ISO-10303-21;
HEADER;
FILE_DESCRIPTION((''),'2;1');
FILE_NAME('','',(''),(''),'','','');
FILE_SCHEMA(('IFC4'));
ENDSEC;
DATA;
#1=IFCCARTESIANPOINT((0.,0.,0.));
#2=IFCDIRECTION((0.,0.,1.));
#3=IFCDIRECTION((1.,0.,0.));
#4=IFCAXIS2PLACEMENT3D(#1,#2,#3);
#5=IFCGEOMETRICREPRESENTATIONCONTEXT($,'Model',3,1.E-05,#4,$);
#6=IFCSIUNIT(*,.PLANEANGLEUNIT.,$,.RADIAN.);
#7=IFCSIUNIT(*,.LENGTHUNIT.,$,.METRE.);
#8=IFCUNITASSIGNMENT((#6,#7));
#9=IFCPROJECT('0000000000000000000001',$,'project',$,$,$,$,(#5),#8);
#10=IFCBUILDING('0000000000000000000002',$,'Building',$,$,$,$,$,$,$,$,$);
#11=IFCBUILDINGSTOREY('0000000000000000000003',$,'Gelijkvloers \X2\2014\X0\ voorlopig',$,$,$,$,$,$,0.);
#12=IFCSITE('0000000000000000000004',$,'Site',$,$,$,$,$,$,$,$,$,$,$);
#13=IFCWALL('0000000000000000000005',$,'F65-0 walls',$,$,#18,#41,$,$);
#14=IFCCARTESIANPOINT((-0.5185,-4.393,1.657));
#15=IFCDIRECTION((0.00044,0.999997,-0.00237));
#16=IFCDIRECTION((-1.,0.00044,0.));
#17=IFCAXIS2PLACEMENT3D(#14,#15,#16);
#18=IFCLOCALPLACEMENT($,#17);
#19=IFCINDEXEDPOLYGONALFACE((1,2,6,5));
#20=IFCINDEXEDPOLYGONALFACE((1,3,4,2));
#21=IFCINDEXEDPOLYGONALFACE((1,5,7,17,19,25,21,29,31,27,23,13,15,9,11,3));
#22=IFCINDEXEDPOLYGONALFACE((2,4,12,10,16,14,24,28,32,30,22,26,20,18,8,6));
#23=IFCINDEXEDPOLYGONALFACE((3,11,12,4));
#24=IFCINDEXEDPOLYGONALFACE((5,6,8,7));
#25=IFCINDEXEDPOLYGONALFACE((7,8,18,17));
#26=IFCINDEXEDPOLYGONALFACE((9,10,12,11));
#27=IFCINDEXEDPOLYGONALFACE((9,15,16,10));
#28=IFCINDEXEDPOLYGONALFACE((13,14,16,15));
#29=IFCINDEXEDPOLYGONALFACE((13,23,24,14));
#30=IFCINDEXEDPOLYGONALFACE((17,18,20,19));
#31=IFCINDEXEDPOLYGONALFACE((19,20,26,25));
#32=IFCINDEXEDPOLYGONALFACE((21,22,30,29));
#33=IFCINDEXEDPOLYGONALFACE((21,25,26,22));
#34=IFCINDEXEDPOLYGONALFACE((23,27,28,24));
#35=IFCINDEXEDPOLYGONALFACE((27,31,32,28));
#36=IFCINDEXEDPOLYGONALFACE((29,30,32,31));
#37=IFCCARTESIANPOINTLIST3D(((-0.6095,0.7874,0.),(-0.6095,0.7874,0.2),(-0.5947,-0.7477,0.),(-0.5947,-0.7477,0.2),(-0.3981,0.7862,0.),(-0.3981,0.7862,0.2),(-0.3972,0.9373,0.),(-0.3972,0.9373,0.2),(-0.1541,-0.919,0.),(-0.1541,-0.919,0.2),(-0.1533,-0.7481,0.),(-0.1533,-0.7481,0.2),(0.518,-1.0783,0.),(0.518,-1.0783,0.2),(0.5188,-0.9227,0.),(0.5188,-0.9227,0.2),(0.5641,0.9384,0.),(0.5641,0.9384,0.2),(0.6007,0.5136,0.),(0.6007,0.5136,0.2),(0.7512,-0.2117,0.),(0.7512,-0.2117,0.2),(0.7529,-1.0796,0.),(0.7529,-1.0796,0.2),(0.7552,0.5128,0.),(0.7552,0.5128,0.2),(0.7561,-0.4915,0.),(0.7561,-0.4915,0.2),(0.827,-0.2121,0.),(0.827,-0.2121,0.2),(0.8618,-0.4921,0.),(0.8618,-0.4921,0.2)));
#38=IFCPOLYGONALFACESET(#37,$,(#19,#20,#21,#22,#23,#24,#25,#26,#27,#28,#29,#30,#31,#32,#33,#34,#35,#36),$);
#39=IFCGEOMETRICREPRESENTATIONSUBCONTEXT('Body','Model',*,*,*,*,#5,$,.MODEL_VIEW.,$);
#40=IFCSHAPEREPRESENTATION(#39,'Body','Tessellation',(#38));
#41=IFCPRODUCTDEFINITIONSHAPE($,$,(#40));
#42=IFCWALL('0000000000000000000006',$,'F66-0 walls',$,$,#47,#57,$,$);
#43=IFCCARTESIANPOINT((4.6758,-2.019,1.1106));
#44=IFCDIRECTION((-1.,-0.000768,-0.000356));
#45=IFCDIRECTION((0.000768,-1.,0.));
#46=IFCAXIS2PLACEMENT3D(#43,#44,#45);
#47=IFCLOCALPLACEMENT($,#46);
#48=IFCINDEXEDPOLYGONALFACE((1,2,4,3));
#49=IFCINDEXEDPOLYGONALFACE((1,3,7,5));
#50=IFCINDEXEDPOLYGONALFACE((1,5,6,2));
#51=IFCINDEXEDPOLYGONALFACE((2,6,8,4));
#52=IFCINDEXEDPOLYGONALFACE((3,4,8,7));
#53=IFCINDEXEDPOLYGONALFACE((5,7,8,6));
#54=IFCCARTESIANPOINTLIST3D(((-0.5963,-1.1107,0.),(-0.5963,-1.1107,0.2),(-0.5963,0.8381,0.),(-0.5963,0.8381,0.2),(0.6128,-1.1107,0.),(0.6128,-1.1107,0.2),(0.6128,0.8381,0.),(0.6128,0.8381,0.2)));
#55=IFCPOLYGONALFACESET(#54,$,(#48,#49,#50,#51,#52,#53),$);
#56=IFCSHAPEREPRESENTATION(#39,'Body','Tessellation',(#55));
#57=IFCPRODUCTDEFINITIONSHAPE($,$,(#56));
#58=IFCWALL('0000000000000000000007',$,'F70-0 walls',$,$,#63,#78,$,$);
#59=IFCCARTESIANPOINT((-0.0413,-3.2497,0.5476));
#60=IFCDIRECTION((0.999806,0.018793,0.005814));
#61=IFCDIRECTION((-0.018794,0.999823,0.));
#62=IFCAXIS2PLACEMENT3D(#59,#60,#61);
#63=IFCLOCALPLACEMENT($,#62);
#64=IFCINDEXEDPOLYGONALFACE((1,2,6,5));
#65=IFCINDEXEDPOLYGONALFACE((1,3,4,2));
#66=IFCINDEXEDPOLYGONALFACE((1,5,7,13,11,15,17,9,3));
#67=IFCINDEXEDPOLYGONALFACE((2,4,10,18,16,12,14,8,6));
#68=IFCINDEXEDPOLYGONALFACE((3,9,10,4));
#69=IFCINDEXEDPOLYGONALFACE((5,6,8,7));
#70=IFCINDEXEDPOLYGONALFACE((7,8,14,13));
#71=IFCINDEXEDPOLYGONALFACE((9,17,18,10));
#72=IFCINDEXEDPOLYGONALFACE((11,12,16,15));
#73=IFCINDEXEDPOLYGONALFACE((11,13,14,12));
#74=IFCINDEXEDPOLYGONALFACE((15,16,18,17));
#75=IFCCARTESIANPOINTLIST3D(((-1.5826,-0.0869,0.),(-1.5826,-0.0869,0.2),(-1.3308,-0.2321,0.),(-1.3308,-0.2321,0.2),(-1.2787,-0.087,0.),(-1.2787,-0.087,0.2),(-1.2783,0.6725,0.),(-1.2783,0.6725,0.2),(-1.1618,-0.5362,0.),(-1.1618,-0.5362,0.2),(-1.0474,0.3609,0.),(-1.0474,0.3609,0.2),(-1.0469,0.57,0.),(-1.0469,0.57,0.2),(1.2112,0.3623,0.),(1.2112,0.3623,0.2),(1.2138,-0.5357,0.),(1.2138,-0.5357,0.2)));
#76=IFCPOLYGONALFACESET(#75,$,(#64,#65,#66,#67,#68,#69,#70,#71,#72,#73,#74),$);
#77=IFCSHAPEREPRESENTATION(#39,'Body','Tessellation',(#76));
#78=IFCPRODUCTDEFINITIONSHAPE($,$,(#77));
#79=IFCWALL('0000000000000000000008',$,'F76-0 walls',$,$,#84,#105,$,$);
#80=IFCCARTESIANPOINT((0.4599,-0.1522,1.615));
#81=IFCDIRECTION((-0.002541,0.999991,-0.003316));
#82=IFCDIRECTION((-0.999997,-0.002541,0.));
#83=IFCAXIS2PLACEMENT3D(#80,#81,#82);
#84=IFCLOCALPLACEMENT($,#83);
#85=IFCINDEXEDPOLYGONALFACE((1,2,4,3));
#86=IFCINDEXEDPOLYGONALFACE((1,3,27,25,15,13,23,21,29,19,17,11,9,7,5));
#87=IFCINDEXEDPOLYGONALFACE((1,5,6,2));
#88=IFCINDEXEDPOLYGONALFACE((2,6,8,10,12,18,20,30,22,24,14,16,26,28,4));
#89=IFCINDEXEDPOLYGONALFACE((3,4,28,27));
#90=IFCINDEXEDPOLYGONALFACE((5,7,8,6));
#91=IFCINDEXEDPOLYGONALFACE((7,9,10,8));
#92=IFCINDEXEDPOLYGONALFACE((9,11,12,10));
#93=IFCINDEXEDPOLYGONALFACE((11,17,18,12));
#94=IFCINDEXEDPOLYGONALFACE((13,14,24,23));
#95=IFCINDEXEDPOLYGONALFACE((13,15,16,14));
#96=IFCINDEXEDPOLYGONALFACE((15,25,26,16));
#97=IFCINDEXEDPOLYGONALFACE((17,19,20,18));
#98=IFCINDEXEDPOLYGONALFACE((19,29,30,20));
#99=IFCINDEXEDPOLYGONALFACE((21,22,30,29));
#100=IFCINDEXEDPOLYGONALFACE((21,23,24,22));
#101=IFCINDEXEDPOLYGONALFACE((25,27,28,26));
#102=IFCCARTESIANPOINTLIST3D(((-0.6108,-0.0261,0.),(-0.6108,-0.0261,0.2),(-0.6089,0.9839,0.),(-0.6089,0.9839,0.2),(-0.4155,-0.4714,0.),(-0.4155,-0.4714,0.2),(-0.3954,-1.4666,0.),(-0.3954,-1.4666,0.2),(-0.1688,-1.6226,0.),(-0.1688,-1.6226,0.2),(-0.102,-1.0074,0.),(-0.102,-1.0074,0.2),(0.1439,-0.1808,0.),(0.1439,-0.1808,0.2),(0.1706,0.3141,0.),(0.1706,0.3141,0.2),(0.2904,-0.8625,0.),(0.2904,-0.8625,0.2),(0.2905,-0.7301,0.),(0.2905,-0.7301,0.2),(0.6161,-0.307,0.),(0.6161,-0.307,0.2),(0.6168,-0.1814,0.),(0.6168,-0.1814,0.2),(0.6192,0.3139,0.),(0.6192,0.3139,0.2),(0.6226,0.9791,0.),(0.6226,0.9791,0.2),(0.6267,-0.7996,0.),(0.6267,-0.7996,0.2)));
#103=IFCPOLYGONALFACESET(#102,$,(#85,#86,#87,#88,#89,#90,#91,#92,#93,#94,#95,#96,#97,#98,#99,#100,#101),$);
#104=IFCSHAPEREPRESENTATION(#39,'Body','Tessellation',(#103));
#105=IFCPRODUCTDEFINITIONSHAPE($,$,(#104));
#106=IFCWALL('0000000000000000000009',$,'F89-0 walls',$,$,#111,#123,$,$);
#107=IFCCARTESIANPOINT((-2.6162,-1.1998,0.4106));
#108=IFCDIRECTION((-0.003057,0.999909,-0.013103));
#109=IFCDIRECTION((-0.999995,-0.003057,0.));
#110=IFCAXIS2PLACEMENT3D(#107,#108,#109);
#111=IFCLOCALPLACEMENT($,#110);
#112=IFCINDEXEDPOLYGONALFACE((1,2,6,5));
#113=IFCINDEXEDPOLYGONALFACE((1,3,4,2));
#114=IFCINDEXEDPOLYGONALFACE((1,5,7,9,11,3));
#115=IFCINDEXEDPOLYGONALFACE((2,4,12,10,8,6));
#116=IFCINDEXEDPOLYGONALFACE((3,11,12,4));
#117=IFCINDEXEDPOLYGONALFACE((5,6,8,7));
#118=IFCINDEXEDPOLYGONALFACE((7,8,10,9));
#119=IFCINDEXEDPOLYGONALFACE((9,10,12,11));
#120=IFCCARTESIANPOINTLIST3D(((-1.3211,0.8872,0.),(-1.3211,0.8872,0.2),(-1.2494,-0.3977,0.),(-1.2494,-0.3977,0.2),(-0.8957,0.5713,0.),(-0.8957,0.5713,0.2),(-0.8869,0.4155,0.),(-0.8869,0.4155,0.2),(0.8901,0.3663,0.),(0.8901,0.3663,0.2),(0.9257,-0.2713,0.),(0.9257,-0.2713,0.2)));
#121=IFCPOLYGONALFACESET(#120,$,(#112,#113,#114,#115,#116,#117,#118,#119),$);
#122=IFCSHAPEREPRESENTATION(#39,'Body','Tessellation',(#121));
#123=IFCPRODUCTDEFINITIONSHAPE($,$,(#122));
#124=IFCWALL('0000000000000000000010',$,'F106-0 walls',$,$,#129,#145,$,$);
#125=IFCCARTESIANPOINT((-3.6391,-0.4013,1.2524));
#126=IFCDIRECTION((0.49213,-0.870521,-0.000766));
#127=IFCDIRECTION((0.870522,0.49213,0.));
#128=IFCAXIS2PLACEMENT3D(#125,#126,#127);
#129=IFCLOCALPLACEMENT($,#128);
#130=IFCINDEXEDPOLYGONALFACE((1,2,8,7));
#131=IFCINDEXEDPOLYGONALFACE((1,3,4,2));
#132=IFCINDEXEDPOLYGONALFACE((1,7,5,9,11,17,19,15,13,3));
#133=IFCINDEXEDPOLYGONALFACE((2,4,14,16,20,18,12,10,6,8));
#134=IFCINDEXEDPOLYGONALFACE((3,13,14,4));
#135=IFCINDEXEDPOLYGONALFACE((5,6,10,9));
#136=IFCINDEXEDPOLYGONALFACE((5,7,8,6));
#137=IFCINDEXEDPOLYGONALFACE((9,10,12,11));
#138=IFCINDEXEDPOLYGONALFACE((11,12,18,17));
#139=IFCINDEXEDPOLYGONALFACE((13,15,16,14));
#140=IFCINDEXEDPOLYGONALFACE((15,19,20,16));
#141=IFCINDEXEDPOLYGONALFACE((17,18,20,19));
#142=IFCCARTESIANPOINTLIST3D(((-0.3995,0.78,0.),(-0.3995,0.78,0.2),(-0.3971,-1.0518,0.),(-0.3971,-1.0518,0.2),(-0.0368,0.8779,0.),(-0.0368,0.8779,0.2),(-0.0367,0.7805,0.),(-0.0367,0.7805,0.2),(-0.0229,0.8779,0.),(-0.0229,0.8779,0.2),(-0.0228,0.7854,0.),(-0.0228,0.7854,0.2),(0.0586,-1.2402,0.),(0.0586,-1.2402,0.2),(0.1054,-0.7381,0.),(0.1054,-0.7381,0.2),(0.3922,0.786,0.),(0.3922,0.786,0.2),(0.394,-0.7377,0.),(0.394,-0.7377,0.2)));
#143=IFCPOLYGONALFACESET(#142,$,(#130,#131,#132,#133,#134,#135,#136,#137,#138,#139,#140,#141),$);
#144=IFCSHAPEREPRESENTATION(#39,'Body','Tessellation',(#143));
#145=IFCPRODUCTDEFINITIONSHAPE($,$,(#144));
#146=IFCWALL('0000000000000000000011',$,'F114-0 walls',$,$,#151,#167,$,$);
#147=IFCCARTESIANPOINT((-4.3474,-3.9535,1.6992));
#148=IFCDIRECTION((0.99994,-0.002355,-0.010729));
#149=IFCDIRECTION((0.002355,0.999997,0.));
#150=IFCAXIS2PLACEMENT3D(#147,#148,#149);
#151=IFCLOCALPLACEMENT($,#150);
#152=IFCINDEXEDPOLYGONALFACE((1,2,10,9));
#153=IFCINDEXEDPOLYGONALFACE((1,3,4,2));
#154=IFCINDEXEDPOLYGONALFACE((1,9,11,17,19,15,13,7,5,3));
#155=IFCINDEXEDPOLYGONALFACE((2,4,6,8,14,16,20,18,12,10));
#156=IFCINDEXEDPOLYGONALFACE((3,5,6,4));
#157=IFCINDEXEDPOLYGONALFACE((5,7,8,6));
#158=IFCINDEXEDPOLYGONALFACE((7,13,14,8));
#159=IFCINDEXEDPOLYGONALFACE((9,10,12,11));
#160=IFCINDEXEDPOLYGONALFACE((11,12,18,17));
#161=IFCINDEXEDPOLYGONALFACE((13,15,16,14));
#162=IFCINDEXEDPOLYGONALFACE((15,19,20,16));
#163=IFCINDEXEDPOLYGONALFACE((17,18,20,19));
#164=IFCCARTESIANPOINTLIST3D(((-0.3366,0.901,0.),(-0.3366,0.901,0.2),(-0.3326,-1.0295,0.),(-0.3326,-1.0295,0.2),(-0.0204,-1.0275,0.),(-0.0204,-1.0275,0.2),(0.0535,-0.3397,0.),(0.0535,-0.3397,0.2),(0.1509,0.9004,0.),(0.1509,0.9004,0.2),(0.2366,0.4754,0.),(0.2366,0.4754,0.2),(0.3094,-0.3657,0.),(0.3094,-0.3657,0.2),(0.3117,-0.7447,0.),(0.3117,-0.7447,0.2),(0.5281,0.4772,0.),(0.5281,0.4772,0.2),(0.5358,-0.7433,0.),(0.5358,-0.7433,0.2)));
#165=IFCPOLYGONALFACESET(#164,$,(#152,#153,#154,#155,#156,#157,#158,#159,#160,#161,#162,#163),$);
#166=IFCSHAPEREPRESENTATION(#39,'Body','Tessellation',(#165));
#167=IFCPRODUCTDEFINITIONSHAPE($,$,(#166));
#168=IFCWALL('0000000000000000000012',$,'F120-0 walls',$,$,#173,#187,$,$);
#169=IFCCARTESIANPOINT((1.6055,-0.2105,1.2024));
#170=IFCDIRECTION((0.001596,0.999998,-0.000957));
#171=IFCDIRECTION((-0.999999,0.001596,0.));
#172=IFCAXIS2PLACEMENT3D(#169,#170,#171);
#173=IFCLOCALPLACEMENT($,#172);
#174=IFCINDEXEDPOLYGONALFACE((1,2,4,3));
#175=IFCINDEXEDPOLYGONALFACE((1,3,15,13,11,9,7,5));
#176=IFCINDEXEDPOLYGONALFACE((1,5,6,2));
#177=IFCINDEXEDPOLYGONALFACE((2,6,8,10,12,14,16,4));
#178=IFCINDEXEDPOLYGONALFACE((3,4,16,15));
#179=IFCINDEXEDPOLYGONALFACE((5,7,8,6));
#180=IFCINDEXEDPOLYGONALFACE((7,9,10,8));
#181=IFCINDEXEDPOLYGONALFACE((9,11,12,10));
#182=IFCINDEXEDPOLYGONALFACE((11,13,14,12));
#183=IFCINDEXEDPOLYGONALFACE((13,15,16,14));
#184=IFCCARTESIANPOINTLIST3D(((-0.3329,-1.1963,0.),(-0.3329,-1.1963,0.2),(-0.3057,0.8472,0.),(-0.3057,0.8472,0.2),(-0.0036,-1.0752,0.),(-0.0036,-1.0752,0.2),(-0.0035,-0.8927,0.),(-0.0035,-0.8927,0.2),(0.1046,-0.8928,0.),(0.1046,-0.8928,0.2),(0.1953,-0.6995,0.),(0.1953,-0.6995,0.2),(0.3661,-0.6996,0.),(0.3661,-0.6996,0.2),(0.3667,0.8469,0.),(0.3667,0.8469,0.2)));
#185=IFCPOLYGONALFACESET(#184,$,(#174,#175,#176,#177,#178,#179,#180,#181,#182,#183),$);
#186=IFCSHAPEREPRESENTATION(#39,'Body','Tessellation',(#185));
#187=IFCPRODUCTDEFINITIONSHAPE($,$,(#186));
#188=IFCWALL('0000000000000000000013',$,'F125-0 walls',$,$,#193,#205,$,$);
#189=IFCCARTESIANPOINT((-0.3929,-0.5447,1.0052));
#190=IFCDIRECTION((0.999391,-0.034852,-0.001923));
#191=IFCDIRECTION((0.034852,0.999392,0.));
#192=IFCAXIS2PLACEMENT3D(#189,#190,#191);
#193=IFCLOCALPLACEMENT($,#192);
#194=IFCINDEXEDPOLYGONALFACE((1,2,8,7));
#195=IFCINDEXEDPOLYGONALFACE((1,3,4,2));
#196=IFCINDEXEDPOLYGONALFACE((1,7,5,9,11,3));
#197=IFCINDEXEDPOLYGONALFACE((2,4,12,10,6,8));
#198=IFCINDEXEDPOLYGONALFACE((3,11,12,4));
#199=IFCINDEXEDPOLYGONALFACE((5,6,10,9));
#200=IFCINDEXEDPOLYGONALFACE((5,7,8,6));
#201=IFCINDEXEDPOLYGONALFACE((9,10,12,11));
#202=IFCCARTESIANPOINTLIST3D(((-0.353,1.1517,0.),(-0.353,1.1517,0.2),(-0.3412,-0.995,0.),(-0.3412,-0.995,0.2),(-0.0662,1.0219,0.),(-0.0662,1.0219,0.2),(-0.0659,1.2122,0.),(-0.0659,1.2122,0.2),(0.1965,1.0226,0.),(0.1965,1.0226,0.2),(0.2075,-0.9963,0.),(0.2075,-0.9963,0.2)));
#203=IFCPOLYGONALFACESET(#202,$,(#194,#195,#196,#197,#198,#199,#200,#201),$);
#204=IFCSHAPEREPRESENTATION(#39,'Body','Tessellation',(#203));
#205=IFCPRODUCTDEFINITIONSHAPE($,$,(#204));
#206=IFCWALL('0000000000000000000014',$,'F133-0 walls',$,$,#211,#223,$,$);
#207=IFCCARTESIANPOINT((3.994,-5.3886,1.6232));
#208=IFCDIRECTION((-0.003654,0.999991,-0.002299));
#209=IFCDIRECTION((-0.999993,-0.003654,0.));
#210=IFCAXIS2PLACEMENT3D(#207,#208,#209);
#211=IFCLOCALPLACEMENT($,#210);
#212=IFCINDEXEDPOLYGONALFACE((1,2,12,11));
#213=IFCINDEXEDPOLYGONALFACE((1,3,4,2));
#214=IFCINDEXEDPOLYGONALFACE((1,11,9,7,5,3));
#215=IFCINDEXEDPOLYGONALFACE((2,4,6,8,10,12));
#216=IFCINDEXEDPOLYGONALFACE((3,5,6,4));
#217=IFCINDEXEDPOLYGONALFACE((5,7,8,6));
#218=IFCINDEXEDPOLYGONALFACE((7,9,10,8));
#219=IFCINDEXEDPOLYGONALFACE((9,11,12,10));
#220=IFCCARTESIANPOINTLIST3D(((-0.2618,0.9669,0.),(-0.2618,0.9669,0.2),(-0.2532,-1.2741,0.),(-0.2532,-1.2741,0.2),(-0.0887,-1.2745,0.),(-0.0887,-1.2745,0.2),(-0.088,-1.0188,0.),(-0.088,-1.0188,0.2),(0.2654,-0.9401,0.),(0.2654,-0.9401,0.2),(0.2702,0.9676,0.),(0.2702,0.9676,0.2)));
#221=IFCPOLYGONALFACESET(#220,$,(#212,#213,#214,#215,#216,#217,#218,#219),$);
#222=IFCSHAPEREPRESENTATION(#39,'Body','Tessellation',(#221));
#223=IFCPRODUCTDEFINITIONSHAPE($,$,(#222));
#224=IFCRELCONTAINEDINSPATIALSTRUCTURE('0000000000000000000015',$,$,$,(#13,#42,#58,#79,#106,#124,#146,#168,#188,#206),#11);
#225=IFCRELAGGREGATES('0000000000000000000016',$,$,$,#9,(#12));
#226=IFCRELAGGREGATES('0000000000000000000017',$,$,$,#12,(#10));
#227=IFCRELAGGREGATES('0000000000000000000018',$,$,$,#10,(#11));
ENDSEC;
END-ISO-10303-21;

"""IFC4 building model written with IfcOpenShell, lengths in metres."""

from ifc_helpers import new_model, si_unit, frame, origin_with_axes, place, context, subcontext, project, spatial, polyline, outline, extrude, element, save


model = new_model("IFC4")

# Units and contexts
model_context = context("Model", 3, precision=1e-05, world=origin_with_axes())
body_context = subcontext(model_context, "Body", "Model", "MODEL_VIEW")
ifc_project = project(units=[si_unit("PLANEANGLEUNIT", "RADIAN"), si_unit("LENGTHUNIT", "METRE")], contexts=[model_context])

# Site, building, storey
site = spatial("IfcSite", under=ifc_project, Name="Site")
building = spatial("IfcBuilding", under=site, Name="Building")
storey = spatial("IfcBuildingStorey", under=building, Name="Gelijkvloers — voorlopig", Elevation=0.0)

# Walls
wall_1_placement = place(None, frame((-0.5185, -4.393, 1.657), z_axis=(0.00044, 0.999997, -0.00237), x_axis=(-1.0, 0.00044, 0.0)))
element("IfcWall", 1, at=wall_1_placement, inside=storey, Name="F65-0 walls", context=body_context, shape_type="SweptSolid", body=[
    extrude(outline(polyline([(0.7529, -1.0796), (0.7561, -0.4915), (0.8618, -0.4921), (0.827, -0.2121), (0.7512, -0.2117), (0.7552, 0.5128), (0.6007, 0.5136), (0.5641, 0.9384), (-0.3972, 0.9373), (-0.3981, 0.7862), (-0.6095, 0.7874), (-0.5947, -0.7477), (-0.1533, -0.7481), (-0.1541, -0.919), (0.5188, -0.9227), (0.518, -1.0783), (0.7529, -1.0796)])), origin_with_axes(), (0.0, 0.0, 1.0), 0.2),
])
wall_2_placement = place(None, frame((4.6758, -2.019, 1.1106), z_axis=(-1.0, -0.000768, -0.000356), x_axis=(0.000768, -1.0, 0.0)))
element("IfcWall", 2, at=wall_2_placement, inside=storey, Name="F66-0 walls", context=body_context, shape_type="SweptSolid", body=[
    extrude(outline(polyline([(-0.5963, -1.1107), (0.6128, -1.1107), (0.6128, 0.8381), (-0.5963, 0.8381), (-0.5963, -1.1107)])), origin_with_axes(), (0.0, 0.0, 1.0), 0.2),
])
wall_3_placement = place(None, frame((-0.0413, -3.2497, 0.5476), z_axis=(0.999806, 0.018793, 0.005814), x_axis=(-0.018794, 0.999823, 0.0)))
element("IfcWall", 3, at=wall_3_placement, inside=storey, Name="F70-0 walls", context=body_context, shape_type="SweptSolid", body=[
    extrude(outline(polyline([(-1.1618, -0.5362), (1.2138, -0.5357), (1.2112, 0.3623), (-1.0474, 0.3609), (-1.0469, 0.57), (-1.2783, 0.6725), (-1.2787, -0.087), (-1.5826, -0.0869), (-1.3308, -0.2321), (-1.1618, -0.5362)])), origin_with_axes(), (0.0, 0.0, 1.0), 0.2),
])
wall_4_placement = place(None, frame((0.4599, -0.1522, 1.615), z_axis=(-0.002541, 0.999991, -0.003316), x_axis=(-0.999997, -0.002541, 0.0)))
element("IfcWall", 4, at=wall_4_placement, inside=storey, Name="F76-0 walls", context=body_context, shape_type="SweptSolid", body=[
    extrude(outline(polyline([(-0.1688, -1.6226), (-0.102, -1.0074), (0.2904, -0.8625), (0.2905, -0.7301), (0.6267, -0.7996), (0.6161, -0.307), (0.6168, -0.1814), (0.1439, -0.1808), (0.1706, 0.3141), (0.6192, 0.3139), (0.6226, 0.9791), (-0.6089, 0.9839), (-0.6108, -0.0261), (-0.4155, -0.4714), (-0.3954, -1.4666), (-0.1688, -1.6226)])), origin_with_axes(), (0.0, 0.0, 1.0), 0.2),
])
wall_5_placement = place(None, frame((-2.6162, -1.1998, 0.4106), z_axis=(-0.003057, 0.999909, -0.013103), x_axis=(-0.999995, -0.003057, 0.0)))
element("IfcWall", 5, at=wall_5_placement, inside=storey, Name="F89-0 walls", context=body_context, shape_type="SweptSolid", body=[
    extrude(outline(polyline([(-1.2494, -0.3977), (0.9257, -0.2713), (0.8901, 0.3663), (-0.8869, 0.4155), (-0.8957, 0.5713), (-1.3211, 0.8872), (-1.2494, -0.3977)])), origin_with_axes(), (0.0, 0.0, 1.0), 0.2),
])
wall_6_placement = place(None, frame((-3.6391, -0.4013, 1.2524), z_axis=(0.49213, -0.870521, -0.000766), x_axis=(0.870522, 0.49213, 0.0)))
element("IfcWall", 6, at=wall_6_placement, inside=storey, Name="F106-0 walls", context=body_context, shape_type="SweptSolid", body=[
    extrude(outline(polyline([(0.0586, -1.2402), (0.1054, -0.7381), (0.394, -0.7377), (0.3922, 0.786), (-0.0228, 0.7854), (-0.0229, 0.8779), (-0.0368, 0.8779), (-0.0367, 0.7805), (-0.3995, 0.78), (-0.3971, -1.0518), (0.0586, -1.2402)])), origin_with_axes(), (0.0, 0.0, 1.0), 0.2),
])
wall_7_placement = place(None, frame((-4.3474, -3.9535, 1.6992), z_axis=(0.99994, -0.002355, -0.010729), x_axis=(0.002355, 0.999997, 0.0)))
element("IfcWall", 7, at=wall_7_placement, inside=storey, Name="F114-0 walls", context=body_context, shape_type="SweptSolid", body=[
    extrude(outline(polyline([(-0.3326, -1.0295), (-0.0204, -1.0275), (0.0535, -0.3397), (0.3094, -0.3657), (0.3117, -0.7447), (0.5358, -0.7433), (0.5281, 0.4772), (0.2366, 0.4754), (0.1509, 0.9004), (-0.3366, 0.901), (-0.3326, -1.0295)])), origin_with_axes(), (0.0, 0.0, 1.0), 0.2),
])
wall_8_placement = place(None, frame((1.6055, -0.2105, 1.2024), z_axis=(0.001596, 0.999998, -0.000957), x_axis=(-0.999999, 0.001596, 0.0)))
element("IfcWall", 8, at=wall_8_placement, inside=storey, Name="F120-0 walls", context=body_context, shape_type="SweptSolid", body=[
    extrude(outline(polyline([(-0.3329, -1.1963), (-0.0036, -1.0752), (-0.0035, -0.8927), (0.1046, -0.8928), (0.1953, -0.6995), (0.3661, -0.6996), (0.3667, 0.8469), (-0.3057, 0.8472), (-0.3329, -1.1963)])), origin_with_axes(), (0.0, 0.0, 1.0), 0.2),
])
wall_9_placement = place(None, frame((-0.3929, -0.5447, 1.0052), z_axis=(0.999391, -0.034852, -0.001923), x_axis=(0.034852, 0.999392, 0.0)))
element("IfcWall", 9, at=wall_9_placement, inside=storey, Name="F125-0 walls", context=body_context, shape_type="SweptSolid", body=[
    extrude(outline(polyline([(-0.3412, -0.995), (0.2075, -0.9963), (0.1965, 1.0226), (-0.0662, 1.0219), (-0.0659, 1.2122), (-0.353, 1.1517), (-0.3412, -0.995)])), origin_with_axes(), (0.0, 0.0, 1.0), 0.2),
])
wall_10_placement = place(None, frame((3.994, -5.3886, 1.6232), z_axis=(-0.003654, 0.999991, -0.002299), x_axis=(-0.999993, -0.003654, 0.0)))
element("IfcWall", 10, at=wall_10_placement, inside=storey, Name="F133-0 walls", context=body_context, shape_type="SweptSolid", body=[
    extrude(outline(polyline([(-0.2532, -1.2741), (-0.0887, -1.2745), (-0.088, -1.0188), (0.2654, -0.9401), (0.2702, 0.9676), (-0.2618, 0.9669), (-0.2532, -1.2741)])), origin_with_axes(), (0.0, 0.0, 1.0), 0.2),
])

save(model, "model.ifc")
